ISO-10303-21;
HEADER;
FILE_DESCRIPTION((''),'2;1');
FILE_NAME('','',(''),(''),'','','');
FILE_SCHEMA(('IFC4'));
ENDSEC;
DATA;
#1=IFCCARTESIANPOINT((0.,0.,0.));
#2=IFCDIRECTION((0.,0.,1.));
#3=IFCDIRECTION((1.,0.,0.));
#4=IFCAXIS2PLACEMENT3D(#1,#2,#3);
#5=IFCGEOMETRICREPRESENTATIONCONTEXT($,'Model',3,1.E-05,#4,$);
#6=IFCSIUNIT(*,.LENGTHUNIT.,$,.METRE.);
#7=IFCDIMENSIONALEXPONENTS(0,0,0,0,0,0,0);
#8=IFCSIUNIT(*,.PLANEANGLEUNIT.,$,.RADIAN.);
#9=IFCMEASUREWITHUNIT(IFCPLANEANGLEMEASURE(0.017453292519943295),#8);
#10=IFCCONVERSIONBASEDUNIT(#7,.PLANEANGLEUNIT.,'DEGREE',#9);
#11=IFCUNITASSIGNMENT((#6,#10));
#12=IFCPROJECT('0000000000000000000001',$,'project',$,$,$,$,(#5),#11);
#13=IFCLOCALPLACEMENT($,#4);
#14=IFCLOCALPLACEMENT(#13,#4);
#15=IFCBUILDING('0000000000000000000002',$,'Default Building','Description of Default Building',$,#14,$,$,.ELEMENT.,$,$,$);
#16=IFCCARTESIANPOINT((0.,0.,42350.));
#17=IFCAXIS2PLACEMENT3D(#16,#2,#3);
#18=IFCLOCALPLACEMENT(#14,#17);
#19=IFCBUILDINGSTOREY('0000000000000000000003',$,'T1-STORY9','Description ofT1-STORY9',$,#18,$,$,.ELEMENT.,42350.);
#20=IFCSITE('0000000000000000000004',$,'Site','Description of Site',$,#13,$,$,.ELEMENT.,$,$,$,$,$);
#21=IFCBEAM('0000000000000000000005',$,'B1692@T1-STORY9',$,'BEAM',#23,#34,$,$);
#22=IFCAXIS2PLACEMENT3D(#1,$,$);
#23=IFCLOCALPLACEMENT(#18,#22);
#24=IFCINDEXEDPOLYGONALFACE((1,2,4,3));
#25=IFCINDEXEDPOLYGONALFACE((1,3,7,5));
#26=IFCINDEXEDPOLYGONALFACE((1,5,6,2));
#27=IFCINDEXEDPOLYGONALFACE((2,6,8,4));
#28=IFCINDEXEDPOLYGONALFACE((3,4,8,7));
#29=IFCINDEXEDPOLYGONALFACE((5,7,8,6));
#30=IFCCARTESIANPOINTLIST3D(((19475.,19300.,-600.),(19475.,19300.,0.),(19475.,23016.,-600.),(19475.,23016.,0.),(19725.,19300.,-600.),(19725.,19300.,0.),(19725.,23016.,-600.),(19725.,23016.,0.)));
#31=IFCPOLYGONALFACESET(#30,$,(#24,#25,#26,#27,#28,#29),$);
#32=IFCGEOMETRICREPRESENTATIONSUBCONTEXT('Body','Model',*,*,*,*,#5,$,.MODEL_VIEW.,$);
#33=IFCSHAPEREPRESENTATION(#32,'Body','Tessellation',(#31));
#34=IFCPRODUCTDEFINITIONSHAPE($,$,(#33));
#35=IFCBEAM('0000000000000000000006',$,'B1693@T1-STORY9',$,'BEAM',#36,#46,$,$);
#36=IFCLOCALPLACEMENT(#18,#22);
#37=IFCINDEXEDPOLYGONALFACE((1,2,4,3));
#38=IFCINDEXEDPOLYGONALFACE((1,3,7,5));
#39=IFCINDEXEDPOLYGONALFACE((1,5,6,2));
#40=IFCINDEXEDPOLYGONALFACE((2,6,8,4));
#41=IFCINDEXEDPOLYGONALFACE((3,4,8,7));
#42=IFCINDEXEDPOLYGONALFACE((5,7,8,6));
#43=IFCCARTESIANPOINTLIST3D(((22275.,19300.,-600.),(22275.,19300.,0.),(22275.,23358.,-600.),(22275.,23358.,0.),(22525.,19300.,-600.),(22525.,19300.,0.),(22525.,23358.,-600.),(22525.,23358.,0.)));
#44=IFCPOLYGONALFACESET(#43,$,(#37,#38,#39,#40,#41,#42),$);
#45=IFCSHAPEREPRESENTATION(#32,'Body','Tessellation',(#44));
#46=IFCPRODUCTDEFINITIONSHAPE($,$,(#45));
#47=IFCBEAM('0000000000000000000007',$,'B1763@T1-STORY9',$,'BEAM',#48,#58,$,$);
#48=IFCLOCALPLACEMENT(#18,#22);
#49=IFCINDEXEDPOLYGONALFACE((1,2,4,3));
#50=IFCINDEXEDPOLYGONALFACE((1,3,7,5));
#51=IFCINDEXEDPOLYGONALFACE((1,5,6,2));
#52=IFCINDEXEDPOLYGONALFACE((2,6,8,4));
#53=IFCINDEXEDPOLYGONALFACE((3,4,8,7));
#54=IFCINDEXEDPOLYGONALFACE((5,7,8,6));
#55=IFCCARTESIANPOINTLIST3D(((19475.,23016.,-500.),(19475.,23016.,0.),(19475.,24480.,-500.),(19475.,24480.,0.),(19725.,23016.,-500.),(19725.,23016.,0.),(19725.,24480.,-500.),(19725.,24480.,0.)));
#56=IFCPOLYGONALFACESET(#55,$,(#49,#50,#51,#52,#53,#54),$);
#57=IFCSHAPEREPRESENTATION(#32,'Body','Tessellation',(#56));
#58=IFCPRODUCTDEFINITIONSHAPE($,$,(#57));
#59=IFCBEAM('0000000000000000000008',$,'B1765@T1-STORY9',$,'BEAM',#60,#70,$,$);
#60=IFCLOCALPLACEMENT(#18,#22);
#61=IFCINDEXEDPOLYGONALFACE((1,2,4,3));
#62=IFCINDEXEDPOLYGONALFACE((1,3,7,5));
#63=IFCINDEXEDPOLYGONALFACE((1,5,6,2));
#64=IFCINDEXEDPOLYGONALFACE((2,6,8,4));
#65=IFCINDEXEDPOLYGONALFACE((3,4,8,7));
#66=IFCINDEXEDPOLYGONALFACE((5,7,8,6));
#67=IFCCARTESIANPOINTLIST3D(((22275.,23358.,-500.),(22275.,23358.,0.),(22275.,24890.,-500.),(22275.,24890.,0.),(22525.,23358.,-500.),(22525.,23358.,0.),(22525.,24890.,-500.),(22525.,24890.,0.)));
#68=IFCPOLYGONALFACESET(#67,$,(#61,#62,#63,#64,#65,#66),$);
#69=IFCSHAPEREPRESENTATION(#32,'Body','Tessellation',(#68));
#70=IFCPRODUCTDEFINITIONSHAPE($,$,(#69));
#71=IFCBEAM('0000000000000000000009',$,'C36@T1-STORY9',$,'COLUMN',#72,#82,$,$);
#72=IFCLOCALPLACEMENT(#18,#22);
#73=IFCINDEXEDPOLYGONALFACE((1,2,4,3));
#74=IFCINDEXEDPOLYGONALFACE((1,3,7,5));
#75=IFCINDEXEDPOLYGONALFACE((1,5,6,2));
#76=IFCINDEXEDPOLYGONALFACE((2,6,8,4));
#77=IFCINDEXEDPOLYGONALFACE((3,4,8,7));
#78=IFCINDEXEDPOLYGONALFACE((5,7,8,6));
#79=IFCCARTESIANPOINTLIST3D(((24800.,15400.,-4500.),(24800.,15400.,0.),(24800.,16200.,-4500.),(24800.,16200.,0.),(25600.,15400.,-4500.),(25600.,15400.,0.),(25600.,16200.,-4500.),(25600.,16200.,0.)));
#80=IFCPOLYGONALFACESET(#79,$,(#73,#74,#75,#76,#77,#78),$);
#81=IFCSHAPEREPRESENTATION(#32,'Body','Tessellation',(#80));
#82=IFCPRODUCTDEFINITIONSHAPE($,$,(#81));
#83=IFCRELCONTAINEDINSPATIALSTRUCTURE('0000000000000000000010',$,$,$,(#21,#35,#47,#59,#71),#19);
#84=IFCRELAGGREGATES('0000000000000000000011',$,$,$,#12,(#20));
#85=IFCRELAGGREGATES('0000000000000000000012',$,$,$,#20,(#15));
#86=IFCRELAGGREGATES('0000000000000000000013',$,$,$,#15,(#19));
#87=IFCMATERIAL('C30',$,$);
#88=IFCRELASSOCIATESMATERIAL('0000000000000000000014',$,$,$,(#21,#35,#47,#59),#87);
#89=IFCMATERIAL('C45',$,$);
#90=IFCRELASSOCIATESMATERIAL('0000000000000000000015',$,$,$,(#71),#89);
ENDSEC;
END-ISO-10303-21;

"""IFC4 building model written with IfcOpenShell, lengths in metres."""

from ifc_helpers import new_model, entity, si_unit, converted_unit, frame, origin_with_axes, place, context, subcontext, project, spatial, rectangle, extrude, material, element, save


model = new_model("IFC4")

# Units and contexts
model_context = context("Model", 3, precision=1e-05, world=origin_with_axes())
body_context = subcontext(model_context, "Body", "Model", "MODEL_VIEW")
ifc_project = project(units=[si_unit("LENGTHUNIT", "METRE"), converted_unit("PLANEANGLEUNIT", "DEGREE", entity("IfcPlaneAngleMeasure", 0.017453292519943295), si_unit("PLANEANGLEUNIT", "RADIAN"), dimensions=[0, 0, 0, 0, 0, 0, 0])], contexts=[model_context])

# Site, building, storey
site_placement = place(None, origin_with_axes())
site = spatial("IfcSite", under=ifc_project, at=site_placement, Name="Site", Description="Description of Site", CompositionType="ELEMENT")
building_placement = place(site_placement, origin_with_axes())
building = spatial("IfcBuilding", under=site, at=building_placement, Name="Default Building", Description="Description of Default Building", CompositionType="ELEMENT")
storey_placement = place(building_placement, frame((0.0, 0.0, 42350.0), z_axis=(0.0, 0.0, 1.0), x_axis=(1.0, 0.0, 0.0)))
storey = spatial("IfcBuildingStorey", under=building, at=storey_placement, Name="T1-STORY9", Description="Description ofT1-STORY9", CompositionType="ELEMENT", Elevation=42350.0)

# Beams
ifc_material_1 = material(Name="C30")
beam_1_placement = place(storey_placement, frame((19600.0, 19300.0, -300.0), z_axis=(0.0, 1.0, 0.0), x_axis=(-1.0, 0.0, 0.0)))
element("IfcBeam", 1, at=beam_1_placement, inside=storey, material=ifc_material_1, Name="B1692@T1-STORY9", ObjectType="BEAM", context=body_context, shape_type="SweptSolid", body=[
    extrude(rectangle(XDim=250.0, YDim=600.0), origin_with_axes(), (0.0, 0.0, 1.0), 3716.0),
])
beam_2_placement = place(storey_placement, frame((22400.0, 19300.0, -300.0), z_axis=(0.0, 1.0, 0.0), x_axis=(-1.0, 0.0, 0.0)))
element("IfcBeam", 2, at=beam_2_placement, inside=storey, material=ifc_material_1, Name="B1693@T1-STORY9", ObjectType="BEAM", context=body_context, shape_type="SweptSolid", body=[
    extrude(rectangle(XDim=250.0, YDim=600.0), origin_with_axes(), (0.0, 0.0, 1.0), 4058.0),
])
beam_3_placement = place(storey_placement, frame((19600.0, 23016.0, -250.0), z_axis=(0.0, 1.0, 0.0), x_axis=(-1.0, 0.0, 0.0)))
element("IfcBeam", 3, at=beam_3_placement, inside=storey, material=ifc_material_1, Name="B1763@T1-STORY9", ObjectType="BEAM", context=body_context, shape_type="SweptSolid", body=[
    extrude(rectangle(XDim=250.0, YDim=500.0), origin_with_axes(), (0.0, 0.0, 1.0), 1464.0),
])
beam_4_placement = place(storey_placement, frame((22400.0, 23358.0, -250.0), z_axis=(0.0, 1.0, 0.0), x_axis=(-1.0, 0.0, 0.0)))
element("IfcBeam", 4, at=beam_4_placement, inside=storey, material=ifc_material_1, Name="B1765@T1-STORY9", ObjectType="BEAM", context=body_context, shape_type="SweptSolid", body=[
    extrude(rectangle(XDim=250.0, YDim=500.0), origin_with_axes(), (0.0, 0.0, 1.0), 1532.0),
])
ifc_material_2 = material(Name="C45")
beam_5_placement = place(storey_placement, frame((25200.0, 15800.0, -4500.0), z_axis=(0.0, 0.0, 1.0), x_axis=(-1.0, 0.0, 0.0)))
element("IfcBeam", 5, at=beam_5_placement, inside=storey, material=ifc_material_2, Name="C36@T1-STORY9", ObjectType="COLUMN", context=body_context, shape_type="SweptSolid", body=[
    extrude(rectangle(XDim=800.0, YDim=800.0), origin_with_axes(), (0.0, 0.0, 1.0), 4500.0),
])

save(model, "model.ifc")
